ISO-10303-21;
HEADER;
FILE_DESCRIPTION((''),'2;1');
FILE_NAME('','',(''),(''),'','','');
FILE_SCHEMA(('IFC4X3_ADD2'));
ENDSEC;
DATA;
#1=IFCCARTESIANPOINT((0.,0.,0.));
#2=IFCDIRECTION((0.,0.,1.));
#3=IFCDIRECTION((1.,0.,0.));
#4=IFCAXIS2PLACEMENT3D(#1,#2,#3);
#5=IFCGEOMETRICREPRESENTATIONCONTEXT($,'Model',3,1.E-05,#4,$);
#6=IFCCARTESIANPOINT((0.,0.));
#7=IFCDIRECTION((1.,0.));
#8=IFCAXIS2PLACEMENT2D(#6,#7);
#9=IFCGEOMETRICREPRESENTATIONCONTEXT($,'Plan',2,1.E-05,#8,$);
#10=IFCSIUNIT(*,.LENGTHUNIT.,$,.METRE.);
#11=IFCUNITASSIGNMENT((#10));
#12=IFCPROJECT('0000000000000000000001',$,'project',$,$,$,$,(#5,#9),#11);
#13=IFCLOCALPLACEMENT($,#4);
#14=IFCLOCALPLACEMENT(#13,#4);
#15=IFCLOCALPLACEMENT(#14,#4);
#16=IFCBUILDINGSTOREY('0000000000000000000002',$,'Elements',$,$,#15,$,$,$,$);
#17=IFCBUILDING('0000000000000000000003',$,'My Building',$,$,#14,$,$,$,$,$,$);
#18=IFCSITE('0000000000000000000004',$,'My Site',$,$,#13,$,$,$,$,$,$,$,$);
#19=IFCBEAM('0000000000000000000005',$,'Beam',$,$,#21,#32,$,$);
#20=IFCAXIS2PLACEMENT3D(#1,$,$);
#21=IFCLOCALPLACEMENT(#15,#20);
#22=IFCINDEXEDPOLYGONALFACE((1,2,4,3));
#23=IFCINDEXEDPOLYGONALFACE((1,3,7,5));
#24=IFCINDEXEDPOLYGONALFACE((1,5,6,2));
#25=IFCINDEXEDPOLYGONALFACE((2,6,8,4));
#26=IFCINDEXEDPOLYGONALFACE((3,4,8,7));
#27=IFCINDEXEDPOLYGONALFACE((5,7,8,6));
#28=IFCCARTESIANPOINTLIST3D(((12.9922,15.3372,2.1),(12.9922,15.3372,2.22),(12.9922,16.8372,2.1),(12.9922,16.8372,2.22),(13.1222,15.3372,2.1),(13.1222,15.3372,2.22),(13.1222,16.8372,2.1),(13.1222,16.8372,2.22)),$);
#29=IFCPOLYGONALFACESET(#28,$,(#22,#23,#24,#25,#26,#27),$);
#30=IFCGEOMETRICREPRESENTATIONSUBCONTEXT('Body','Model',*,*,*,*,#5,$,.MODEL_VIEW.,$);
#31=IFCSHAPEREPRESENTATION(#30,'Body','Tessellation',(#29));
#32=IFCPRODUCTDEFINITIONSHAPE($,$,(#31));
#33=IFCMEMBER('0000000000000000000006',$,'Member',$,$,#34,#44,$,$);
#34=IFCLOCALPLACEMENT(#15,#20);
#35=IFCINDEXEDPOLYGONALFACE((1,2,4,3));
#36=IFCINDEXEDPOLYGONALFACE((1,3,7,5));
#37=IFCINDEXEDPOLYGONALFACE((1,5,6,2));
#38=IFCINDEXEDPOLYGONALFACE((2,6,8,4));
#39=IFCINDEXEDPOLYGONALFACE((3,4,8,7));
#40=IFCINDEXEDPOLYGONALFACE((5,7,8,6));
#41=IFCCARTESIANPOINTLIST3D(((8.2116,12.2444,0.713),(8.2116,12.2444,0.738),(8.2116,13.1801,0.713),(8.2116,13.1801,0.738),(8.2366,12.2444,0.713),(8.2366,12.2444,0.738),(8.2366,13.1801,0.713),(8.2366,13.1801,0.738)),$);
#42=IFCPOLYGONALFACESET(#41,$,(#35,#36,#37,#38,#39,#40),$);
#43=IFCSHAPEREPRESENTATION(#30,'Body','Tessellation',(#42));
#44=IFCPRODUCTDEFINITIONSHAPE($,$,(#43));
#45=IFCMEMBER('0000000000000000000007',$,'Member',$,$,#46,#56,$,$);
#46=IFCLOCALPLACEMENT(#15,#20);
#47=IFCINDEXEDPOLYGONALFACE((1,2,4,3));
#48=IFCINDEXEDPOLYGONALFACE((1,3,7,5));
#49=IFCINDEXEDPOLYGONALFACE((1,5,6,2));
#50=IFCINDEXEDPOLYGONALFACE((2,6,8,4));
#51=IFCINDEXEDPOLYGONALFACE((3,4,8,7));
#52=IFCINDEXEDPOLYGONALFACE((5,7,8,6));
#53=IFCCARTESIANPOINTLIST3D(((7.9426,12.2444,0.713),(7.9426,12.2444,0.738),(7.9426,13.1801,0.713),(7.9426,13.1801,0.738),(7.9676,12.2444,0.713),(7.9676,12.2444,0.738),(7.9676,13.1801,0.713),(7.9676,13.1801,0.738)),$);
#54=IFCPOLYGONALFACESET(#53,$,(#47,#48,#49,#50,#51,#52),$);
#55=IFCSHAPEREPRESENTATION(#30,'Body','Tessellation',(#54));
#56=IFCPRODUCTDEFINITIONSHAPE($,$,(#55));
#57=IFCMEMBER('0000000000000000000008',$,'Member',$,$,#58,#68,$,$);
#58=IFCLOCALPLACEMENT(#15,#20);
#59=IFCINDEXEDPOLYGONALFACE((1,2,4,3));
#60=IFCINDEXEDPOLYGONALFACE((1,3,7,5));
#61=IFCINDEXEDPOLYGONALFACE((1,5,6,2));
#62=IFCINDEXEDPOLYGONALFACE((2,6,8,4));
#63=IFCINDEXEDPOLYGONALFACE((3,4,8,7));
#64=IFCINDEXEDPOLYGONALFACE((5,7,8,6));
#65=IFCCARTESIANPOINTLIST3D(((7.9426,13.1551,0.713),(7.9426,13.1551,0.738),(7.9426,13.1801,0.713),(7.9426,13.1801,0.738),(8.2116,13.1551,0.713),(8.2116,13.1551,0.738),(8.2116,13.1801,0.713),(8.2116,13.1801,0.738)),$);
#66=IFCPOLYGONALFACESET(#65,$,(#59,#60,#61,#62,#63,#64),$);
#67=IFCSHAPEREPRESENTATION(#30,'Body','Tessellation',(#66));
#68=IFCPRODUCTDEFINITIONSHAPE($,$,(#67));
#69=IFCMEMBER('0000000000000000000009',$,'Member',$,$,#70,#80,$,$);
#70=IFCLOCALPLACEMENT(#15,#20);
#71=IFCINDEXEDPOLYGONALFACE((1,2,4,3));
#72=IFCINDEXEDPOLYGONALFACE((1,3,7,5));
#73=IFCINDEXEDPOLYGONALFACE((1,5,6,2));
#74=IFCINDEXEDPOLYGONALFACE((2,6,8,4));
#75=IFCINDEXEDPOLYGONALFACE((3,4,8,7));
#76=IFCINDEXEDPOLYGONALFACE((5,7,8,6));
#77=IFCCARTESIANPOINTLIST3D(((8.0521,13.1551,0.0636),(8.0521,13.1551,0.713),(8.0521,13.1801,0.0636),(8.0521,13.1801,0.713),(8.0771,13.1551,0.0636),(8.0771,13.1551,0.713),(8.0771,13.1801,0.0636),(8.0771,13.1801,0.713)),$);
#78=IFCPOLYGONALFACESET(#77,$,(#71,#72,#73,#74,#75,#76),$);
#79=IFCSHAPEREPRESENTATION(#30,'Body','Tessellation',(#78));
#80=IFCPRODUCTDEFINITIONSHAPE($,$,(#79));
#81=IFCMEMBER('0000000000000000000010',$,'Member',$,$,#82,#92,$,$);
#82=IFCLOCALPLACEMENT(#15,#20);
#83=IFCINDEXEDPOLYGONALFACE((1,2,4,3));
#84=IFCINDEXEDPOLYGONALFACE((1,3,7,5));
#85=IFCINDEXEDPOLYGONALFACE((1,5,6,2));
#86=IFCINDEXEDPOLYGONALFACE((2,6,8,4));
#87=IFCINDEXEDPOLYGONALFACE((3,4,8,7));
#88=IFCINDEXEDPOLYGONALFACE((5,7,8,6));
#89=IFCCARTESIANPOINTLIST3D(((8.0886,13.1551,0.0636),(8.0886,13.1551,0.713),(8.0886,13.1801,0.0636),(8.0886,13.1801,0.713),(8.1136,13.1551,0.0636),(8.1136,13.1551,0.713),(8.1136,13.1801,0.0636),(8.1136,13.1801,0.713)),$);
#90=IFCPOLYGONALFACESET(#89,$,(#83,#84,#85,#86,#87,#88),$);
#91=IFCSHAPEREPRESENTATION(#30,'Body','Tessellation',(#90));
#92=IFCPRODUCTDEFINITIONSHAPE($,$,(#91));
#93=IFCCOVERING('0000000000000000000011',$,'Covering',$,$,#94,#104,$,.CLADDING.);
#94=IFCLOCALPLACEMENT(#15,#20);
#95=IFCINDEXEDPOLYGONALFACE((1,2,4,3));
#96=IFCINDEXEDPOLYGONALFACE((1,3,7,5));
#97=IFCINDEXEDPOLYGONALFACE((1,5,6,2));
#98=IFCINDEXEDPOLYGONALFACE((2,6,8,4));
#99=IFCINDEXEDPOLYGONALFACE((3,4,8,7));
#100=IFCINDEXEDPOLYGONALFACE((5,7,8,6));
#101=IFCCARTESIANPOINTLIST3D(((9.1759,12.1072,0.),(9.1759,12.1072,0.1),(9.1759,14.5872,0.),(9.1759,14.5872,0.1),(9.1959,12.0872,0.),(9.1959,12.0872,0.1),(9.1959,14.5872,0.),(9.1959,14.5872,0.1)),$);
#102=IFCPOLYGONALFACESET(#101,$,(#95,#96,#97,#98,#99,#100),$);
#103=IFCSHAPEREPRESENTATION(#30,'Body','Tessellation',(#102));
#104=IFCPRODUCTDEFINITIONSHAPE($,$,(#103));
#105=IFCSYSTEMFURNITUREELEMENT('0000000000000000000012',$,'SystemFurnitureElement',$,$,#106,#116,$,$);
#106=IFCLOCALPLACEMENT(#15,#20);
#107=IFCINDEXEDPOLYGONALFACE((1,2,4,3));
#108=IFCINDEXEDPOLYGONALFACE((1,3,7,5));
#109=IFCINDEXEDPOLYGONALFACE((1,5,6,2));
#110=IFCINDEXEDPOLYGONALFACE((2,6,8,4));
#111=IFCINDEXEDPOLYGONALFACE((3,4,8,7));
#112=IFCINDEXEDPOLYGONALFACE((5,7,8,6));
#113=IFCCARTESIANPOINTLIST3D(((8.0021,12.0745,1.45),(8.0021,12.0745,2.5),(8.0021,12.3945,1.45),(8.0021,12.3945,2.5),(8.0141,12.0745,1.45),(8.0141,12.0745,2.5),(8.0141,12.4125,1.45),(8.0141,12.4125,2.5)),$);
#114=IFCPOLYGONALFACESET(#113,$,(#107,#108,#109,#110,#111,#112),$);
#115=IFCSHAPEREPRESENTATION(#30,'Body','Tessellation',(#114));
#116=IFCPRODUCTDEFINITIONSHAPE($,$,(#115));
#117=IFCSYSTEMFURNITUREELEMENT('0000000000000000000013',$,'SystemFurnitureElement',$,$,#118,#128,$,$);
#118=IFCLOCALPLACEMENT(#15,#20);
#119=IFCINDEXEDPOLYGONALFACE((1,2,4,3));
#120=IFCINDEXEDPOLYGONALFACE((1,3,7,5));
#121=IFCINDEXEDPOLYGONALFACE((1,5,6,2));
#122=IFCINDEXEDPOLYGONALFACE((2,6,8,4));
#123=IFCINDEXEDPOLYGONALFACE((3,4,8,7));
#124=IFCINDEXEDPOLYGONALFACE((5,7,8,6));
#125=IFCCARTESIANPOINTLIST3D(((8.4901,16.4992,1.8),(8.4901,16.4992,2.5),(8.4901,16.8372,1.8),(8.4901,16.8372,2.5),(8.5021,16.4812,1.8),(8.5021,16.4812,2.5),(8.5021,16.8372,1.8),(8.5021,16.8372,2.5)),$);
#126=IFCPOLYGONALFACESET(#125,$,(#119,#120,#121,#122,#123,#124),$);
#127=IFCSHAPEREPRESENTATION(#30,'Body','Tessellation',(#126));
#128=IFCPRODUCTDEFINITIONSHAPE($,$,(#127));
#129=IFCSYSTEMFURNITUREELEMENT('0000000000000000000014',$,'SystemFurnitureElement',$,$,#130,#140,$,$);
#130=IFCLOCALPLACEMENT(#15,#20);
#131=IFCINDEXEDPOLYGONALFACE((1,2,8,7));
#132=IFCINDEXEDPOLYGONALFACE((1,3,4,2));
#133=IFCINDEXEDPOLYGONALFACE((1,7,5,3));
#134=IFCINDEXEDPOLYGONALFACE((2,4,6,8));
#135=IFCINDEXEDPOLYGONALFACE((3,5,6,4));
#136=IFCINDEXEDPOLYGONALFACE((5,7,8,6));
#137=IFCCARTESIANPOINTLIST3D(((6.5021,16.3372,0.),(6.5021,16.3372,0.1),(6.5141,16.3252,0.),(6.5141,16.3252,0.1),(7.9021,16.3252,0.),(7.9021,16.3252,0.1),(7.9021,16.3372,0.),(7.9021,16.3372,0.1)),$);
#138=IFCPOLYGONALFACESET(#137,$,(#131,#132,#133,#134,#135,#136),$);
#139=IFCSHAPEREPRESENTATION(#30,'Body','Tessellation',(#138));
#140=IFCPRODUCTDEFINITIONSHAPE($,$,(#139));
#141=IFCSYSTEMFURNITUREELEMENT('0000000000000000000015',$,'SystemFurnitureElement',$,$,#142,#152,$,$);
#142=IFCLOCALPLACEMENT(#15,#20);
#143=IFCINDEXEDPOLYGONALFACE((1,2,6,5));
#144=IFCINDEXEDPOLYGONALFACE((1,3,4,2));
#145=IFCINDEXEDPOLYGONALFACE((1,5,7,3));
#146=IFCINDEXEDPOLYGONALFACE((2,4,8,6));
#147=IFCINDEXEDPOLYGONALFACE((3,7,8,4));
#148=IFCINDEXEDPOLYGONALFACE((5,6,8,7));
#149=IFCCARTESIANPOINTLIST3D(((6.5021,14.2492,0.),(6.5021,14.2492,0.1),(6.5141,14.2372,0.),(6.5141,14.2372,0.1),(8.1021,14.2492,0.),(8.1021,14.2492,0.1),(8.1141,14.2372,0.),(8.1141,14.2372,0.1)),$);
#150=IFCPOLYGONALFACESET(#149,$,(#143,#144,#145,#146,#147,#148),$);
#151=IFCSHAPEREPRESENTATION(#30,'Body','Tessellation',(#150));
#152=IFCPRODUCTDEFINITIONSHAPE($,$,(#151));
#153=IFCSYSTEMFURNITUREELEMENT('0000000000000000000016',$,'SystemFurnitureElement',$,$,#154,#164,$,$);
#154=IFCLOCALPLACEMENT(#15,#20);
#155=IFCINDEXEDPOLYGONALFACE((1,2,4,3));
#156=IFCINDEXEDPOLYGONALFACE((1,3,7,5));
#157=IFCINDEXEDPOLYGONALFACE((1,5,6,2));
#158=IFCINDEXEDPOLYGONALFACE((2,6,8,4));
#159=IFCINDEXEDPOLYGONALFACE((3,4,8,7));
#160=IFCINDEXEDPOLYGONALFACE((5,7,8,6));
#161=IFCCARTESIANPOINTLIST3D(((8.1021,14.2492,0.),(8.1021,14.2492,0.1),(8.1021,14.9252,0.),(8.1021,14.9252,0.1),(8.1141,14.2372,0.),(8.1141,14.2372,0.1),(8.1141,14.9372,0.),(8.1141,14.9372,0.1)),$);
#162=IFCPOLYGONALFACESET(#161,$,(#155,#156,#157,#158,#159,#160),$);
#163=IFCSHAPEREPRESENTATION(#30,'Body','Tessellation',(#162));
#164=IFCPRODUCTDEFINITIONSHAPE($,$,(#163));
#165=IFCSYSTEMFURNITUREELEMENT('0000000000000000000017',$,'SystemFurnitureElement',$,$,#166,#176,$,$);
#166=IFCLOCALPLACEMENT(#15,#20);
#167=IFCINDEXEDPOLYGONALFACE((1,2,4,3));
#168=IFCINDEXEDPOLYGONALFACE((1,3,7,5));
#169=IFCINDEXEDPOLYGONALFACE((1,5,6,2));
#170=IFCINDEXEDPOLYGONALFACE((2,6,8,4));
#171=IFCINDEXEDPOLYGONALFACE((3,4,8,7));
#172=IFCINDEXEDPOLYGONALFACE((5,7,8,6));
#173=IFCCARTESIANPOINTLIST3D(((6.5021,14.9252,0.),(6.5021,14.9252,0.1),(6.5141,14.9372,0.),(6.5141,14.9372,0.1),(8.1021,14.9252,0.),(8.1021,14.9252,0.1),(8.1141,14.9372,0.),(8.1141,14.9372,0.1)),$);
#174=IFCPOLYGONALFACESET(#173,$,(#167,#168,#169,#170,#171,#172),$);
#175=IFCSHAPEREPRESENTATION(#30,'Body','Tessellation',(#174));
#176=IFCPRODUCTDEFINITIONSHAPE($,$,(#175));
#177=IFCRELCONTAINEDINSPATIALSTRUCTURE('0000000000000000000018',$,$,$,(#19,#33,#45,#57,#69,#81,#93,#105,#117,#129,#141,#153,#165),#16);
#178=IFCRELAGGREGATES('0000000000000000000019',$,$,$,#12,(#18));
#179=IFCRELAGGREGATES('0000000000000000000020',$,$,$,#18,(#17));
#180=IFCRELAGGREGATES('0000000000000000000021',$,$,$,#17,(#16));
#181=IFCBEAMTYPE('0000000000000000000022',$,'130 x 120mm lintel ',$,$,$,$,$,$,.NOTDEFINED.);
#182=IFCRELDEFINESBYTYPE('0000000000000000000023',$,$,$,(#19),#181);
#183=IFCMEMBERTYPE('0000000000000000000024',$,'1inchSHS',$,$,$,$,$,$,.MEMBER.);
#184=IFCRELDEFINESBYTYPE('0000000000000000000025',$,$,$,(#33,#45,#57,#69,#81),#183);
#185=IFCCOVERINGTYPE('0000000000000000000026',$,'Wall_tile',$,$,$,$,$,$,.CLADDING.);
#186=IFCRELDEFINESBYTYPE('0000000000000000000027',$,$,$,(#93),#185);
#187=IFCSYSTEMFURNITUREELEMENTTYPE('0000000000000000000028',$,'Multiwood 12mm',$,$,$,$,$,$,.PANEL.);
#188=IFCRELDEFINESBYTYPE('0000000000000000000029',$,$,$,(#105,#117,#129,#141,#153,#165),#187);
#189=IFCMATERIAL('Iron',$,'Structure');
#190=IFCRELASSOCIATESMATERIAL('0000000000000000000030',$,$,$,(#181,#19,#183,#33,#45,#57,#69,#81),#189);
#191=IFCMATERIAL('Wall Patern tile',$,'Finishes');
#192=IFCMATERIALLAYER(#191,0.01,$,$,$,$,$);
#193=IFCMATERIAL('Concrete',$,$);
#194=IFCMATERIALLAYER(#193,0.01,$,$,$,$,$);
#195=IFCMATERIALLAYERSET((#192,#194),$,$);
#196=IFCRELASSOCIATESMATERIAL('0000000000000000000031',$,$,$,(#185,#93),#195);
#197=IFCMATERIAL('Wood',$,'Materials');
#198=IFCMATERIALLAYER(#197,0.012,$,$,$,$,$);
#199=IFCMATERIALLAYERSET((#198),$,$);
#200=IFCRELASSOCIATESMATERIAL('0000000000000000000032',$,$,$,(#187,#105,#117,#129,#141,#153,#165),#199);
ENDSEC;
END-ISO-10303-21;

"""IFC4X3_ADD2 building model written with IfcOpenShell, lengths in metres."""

from ifc_helpers import new_model, si_unit, frame, origin_with_axes, origin_2d_with_axis, place, context, subcontext, project, spatial, line, indexed_curve, rectangle, outline, extrude, material, layer, layer_set, layer_usage, material_profile, profile_set, profile_usage, type_object, element, save


model = new_model("IFC4X3_ADD2")

# Units and contexts
model_context = context("Model", 3, precision=1e-05, world=origin_with_axes())
plan_context = context("Plan", 2, precision=1e-05, world=origin_2d_with_axis())
body_context = subcontext(model_context, "Body", "Model", "MODEL_VIEW")
ifc_project = project(units=[si_unit("LENGTHUNIT", "METRE")], contexts=[model_context, plan_context])

# Site, building, storey
site_placement = place(None, origin_with_axes())
site = spatial("IfcSite", under=ifc_project, at=site_placement, Name="My Site")
building_placement = place(site_placement, origin_with_axes())
building = spatial("IfcBuilding", under=site, at=building_placement, Name="My Building")
storey_placement = place(building_placement, origin_with_axes())
storey = spatial("IfcBuildingStorey", under=building, at=storey_placement, Name="Elements")

# Beam
ifc_material_1 = material(Name="Iron", Category="Structure")
ifc_material_profile_1 = material_profile(ifc_material_1, rectangle(XDim=0.13, YDim=0.12))
ifc_profile_set_1 = profile_set([ifc_material_profile_1], Name="blank")
ifc_profile_usage_1 = profile_usage(ifc_profile_set_1, cardinal=5)
beam_type = type_object("IfcBeamType", Name="130 x 120mm lintel ", PredefinedType="NOTDEFINED", material=ifc_profile_set_1)
beam_placement = place(storey_placement, frame((13.0572, 16.8372, 2.16), z_axis=(0.0, -1.0, 0.0), x_axis=(1.0, 0.0, 0.0)))
element("IfcBeam", 1, at=beam_placement, inside=storey, type_object=beam_type, material=ifc_profile_usage_1, Name="Beam", context=body_context, shape_type="SweptSolid", body=[
    extrude(rectangle(XDim=0.13, YDim=0.12), origin_with_axes(), (0.0, 0.0, 1.0), 1.5),
])

# Members
ifc_material_profile_2 = material_profile(ifc_material_1, rectangle(XDim=0.025, YDim=0.025))
ifc_profile_set_2 = profile_set([ifc_material_profile_2])
ifc_profile_usage_2 = profile_usage(ifc_profile_set_2, cardinal=5)
member_type = type_object("IfcMemberType", Name="1inchSHS", PredefinedType="MEMBER", material=ifc_profile_set_2)
member_1_placement = place(storey_placement, frame((8.2241, 12.2444, 0.7255), z_axis=(0.0, 1.0, 0.0), x_axis=(-1.0, 0.0, 0.0)))
element("IfcMember", 2, at=member_1_placement, inside=storey, type_object=member_type, material=ifc_profile_usage_2, Name="Member", context=body_context, shape_type="SweptSolid", body=[
    extrude(rectangle(XDim=0.025, YDim=0.025), origin_with_axes(), (0.0, 0.0, 1.0), 0.9357),
])
ifc_profile_usage_3 = profile_usage(ifc_profile_set_2, cardinal=5)
member_2_placement = place(storey_placement, frame((7.9551, 12.2444, 0.7255), z_axis=(0.0, 1.0, 0.0), x_axis=(-1.0, 0.0, 0.0)))
element("IfcMember", 3, at=member_2_placement, inside=storey, type_object=member_type, material=ifc_profile_usage_3, Name="Member", context=body_context, shape_type="SweptSolid", body=[
    extrude(rectangle(XDim=0.025, YDim=0.025), origin_with_axes(), (0.0, 0.0, 1.0), 0.9357),
])
ifc_profile_usage_4 = profile_usage(ifc_profile_set_2, cardinal=5)
member_3_placement = place(storey_placement, frame((7.9426, 13.1676, 0.7255), z_axis=(1.0, 0.0, 0.0), x_axis=(0.0, 1.0, 0.0)))
element("IfcMember", 4, at=member_3_placement, inside=storey, type_object=member_type, material=ifc_profile_usage_4, Name="Member", context=body_context, shape_type="SweptSolid", body=[
    extrude(rectangle(XDim=0.025, YDim=0.025), origin_with_axes(), (0.0, 0.0, 1.0), 0.269),
])
ifc_profile_usage_5 = profile_usage(ifc_profile_set_2, cardinal=5)
member_4_placement = place(storey_placement, frame((8.0646, 13.1676, 0.0636), z_axis=(0.000001, 0.0, 1.0), x_axis=(0.0, 1.0, 0.0)))
element("IfcMember", 5, at=member_4_placement, inside=storey, type_object=member_type, material=ifc_profile_usage_5, Name="Member", context=body_context, shape_type="SweptSolid", body=[
    extrude(rectangle(XDim=0.025, YDim=0.025), origin_with_axes(), (0.0, 0.0, 1.0), 0.6494),
])
ifc_profile_usage_6 = profile_usage(ifc_profile_set_2, cardinal=5)
member_5_placement = place(storey_placement, frame((8.1011, 13.1676, 0.0636), z_axis=(0.000001, 0.0, 1.0), x_axis=(0.0, 1.0, 0.0)))
element("IfcMember", 6, at=member_5_placement, inside=storey, type_object=member_type, material=ifc_profile_usage_6, Name="Member", context=body_context, shape_type="SweptSolid", body=[
    extrude(rectangle(XDim=0.025, YDim=0.025), origin_with_axes(), (0.0, 0.0, 1.0), 0.6494),
])

# Covering
ifc_material_2 = material(Name="Wall Patern tile", Category="Finishes")
ifc_layer_1 = layer(ifc_material_2, 0.01)
ifc_material_3 = material(Name="Concrete")
ifc_layer_2 = layer(ifc_material_3, 0.01)
ifc_layer_set_1 = layer_set([ifc_layer_1, ifc_layer_2])
ifc_layer_usage_1 = layer_usage(ifc_layer_set_1, "AXIS2", "POSITIVE", 0.0)
covering_type = type_object("IfcCoveringType", Name="Wall_tile", PredefinedType="CLADDING", material=ifc_layer_set_1)
covering_placement = place(storey_placement, frame((9.1959, 12.0872, 0.0), z_axis=(0.0, 0.0, 1.0), x_axis=(0.0, 1.0, 0.0)))
element("IfcCovering", 7, at=covering_placement, inside=storey, type_object=covering_type, material=ifc_layer_usage_1, Name="Covering", PredefinedType="CLADDING", context=body_context, shape_type="SweptSolid", body=[
    extrude(outline(indexed_curve([(0.0, 0.0), (0.02, 0.02), (2.5, 0.02), (2.5, 0.0)], segments=[line(1, 2, 3, 4, 1)])), origin_with_axes(), (0.0, 0.0, 1.0), 0.1),
])

# System furniture elements
ifc_material_4 = material(Name="Wood", Category="Materials")
ifc_layer_3 = layer(ifc_material_4, 0.012)
ifc_layer_set_2 = layer_set([ifc_layer_3])
system_furniture_element_type_1 = type_object("IfcSystemFurnitureElementType", Name="Multiwood 12mm", PredefinedType="PANEL", material=ifc_layer_set_2)
ifc_layer_usage_2 = layer_usage(ifc_layer_set_2, "AXIS2", "POSITIVE", 0.0)
system_furniture_element_1_placement = place(storey_placement, frame((8.0021, 12.4125, 1.45), z_axis=(0.0, 0.0, 1.0), x_axis=(0.0, -1.0, 0.0)))
element("IfcSystemFurnitureElement", 8, at=system_furniture_element_1_placement, inside=storey, type_object=system_furniture_element_type_1, material=ifc_layer_usage_2, Name="SystemFurnitureElement", context=body_context, shape_type="SweptSolid", body=[
    extrude(outline(indexed_curve([(0.018, 0.0), (0.0, 0.012), (0.338, 0.012), (0.338, 0.0)], segments=[line(1, 2, 3, 4, 1)])), origin_with_axes(), (0.0, 0.0, 1.0), 1.05),
])
ifc_layer_usage_3 = layer_usage(ifc_layer_set_2, "AXIS2", "POSITIVE", 0.0)
system_furniture_element_2_placement = place(storey_placement, frame((8.4901, 16.8372, 1.8), z_axis=(0.0, 0.0, 1.0), x_axis=(-0.000001, -1.0, 0.0)))
element("IfcSystemFurnitureElement", 9, at=system_furniture_element_2_placement, inside=storey, type_object=system_furniture_element_type_1, material=ifc_layer_usage_3, Name="SystemFurnitureElement", context=body_context, shape_type="SweptSolid", body=[
    extrude(outline(indexed_curve([(0.0, 0.0), (0.0, 0.012), (0.356, 0.012), (0.338, 0.0)], segments=[line(1, 2, 3, 4, 1)])), origin_with_axes(), (0.0, 0.0, 1.0), 0.7),
])
ifc_layer_usage_4 = layer_usage(ifc_layer_set_2, "AXIS2", "POSITIVE", 0.0)
system_furniture_element_3_placement = place(storey_placement, frame((7.9021, 16.3372, 0.0), z_axis=(0.0, 0.0, 1.0), x_axis=(-1.0, 0.0, 0.0)))
element("IfcSystemFurnitureElement", 10, at=system_furniture_element_3_placement, inside=storey, type_object=system_furniture_element_type_1, material=ifc_layer_usage_4, Name="SystemFurnitureElement", context=body_context, shape_type="SweptSolid", body=[
    extrude(outline(indexed_curve([(0.0, 0.0), (0.0, 0.012), (1.388, 0.012), (1.4, 0.0)], segments=[line(1, 2, 3, 4, 1)])), origin_with_axes(), (0.0, 0.0, 1.0), 0.1),
])
ifc_layer_usage_5 = layer_usage(ifc_layer_set_2, "AXIS2", "POSITIVE", 0.0)
system_furniture_element_4_placement = place(storey_placement, frame((8.1021, 14.2492, 0.0), z_axis=(0.0, 0.0, 1.0), x_axis=(-1.0, 0.0, 0.0)))
element("IfcSystemFurnitureElement", 11, at=system_furniture_element_4_placement, inside=storey, type_object=system_furniture_element_type_1, material=ifc_layer_usage_5, Name="SystemFurnitureElement", context=body_context, shape_type="SweptSolid", body=[
    extrude(outline(indexed_curve([(0.0, 0.0), (-0.012, 0.012), (1.588, 0.012), (1.6, 0.0)], segments=[line(1, 2, 3, 4, 1)])), origin_with_axes(), (0.0, 0.0, 1.0), 0.1),
])
ifc_layer_usage_6 = layer_usage(ifc_layer_set_2, "AXIS2", "POSITIVE", 0.0)
system_furniture_element_5_placement = place(storey_placement, frame((8.1021, 14.9372, 0.0), z_axis=(0.0, 0.0, 1.0), x_axis=(0.0, -1.0, 0.0)))
element("IfcSystemFurnitureElement", 12, at=system_furniture_element_5_placement, inside=storey, type_object=system_furniture_element_type_1, material=ifc_layer_usage_6, Name="SystemFurnitureElement", context=body_context, shape_type="SweptSolid", body=[
    extrude(outline(indexed_curve([(0.012, 0.0), (0.0, 0.012), (0.6999, 0.012), (0.6879, 0.0)], segments=[line(1, 2, 3, 4, 1)])), origin_with_axes(), (0.0, 0.0, 1.0), 0.1),
])
ifc_layer_usage_7 = layer_usage(ifc_layer_set_2, "AXIS2", "POSITIVE", 0.0)
system_furniture_element_6_placement = place(storey_placement, frame((8.1021, 14.9372, 0.0), z_axis=(0.0, 0.0, 1.0), x_axis=(-1.0, 0.0, 0.0)))
element("IfcSystemFurnitureElement", 13, at=system_furniture_element_6_placement, inside=storey, type_object=system_furniture_element_type_1, material=ifc_layer_usage_7, Name="SystemFurnitureElement", context=body_context, shape_type="SweptSolid", body=[
    extrude(outline(indexed_curve([(-0.012, 0.0), (0.0, 0.012), (1.6, 0.012), (1.588, 0.0)], segments=[line(1, 2, 3, 4, 1)])), origin_with_axes(), (0.0, 0.0, 1.0), 0.1),
])

save(model, "model.ifc")
